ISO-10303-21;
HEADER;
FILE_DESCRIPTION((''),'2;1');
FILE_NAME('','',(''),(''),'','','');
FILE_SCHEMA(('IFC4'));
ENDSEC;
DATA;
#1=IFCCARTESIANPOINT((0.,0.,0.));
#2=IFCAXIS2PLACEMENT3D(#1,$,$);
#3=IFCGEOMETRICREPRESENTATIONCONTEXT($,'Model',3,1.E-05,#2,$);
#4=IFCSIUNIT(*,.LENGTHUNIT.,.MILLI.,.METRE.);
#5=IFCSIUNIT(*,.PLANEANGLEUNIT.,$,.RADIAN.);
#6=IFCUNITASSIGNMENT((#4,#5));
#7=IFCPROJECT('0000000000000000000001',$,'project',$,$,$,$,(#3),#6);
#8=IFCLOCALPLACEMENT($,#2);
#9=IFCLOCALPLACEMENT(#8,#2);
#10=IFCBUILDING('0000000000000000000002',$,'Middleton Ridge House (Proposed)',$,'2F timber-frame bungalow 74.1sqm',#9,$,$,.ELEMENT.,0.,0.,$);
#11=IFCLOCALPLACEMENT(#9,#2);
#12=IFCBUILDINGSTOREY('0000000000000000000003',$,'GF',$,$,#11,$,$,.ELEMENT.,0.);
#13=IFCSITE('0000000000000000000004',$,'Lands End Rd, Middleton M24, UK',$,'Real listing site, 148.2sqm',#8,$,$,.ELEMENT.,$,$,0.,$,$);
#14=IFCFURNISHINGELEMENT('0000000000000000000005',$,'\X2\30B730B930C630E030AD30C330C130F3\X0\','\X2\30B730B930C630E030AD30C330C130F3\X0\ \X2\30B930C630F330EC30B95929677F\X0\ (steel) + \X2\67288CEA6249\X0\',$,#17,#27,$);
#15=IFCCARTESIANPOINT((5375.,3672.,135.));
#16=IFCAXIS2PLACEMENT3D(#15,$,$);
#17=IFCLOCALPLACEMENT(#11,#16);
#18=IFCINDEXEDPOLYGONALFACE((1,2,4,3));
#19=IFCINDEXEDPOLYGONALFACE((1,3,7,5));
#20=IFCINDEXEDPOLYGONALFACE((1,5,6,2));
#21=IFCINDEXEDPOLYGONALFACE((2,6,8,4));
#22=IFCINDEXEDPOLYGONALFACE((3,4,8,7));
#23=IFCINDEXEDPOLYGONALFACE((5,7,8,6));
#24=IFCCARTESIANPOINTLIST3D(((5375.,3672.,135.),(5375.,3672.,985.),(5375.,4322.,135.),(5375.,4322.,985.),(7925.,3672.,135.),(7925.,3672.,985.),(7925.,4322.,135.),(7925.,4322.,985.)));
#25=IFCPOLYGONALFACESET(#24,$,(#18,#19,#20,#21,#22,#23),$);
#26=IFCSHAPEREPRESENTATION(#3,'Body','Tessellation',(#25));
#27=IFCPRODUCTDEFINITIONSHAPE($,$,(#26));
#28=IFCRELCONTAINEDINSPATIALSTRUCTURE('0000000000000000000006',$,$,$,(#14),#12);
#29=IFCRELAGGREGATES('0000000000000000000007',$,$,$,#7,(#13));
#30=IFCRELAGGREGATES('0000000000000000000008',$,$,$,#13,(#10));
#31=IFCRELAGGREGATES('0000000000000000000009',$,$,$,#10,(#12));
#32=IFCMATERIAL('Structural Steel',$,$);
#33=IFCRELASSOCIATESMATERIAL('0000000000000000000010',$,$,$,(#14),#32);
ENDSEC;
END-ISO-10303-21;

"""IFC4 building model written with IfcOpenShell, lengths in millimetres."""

from ifc_helpers import new_model, si_unit, frame, frame_2d, origin, place, context, project, spatial, rectangle, extrude, material, element, save


model = new_model("IFC4")

# Units and contexts
model_context = context("Model", 3, precision=1e-05, world=origin())
ifc_project = project(units=[si_unit("LENGTHUNIT", "METRE", prefix="MILLI"), si_unit("PLANEANGLEUNIT", "RADIAN")], contexts=[model_context])

# Site, building, storey
site_placement = place(None, origin())
site = spatial("IfcSite", under=ifc_project, at=site_placement, Name="Lands End Rd, Middleton M24, UK", ObjectType="Real listing site, 148.2sqm", CompositionType="ELEMENT", RefElevation=0.0)
building_placement = place(site_placement, origin())
building = spatial("IfcBuilding", under=site, at=building_placement, Name="Middleton Ridge House (Proposed)", ObjectType="2F timber-frame bungalow 74.1sqm", CompositionType="ELEMENT", ElevationOfRefHeight=0.0, ElevationOfTerrain=0.0)
storey_placement = place(building_placement, origin())
storey = spatial("IfcBuildingStorey", under=building, at=storey_placement, Name="GF", CompositionType="ELEMENT", Elevation=0.0)

# Furnishing element
ifc_material_1 = material(Name="Structural Steel")
furnishing_1_placement = place(storey_placement, frame((5375.0, 3672.0, 135.0)))
element("IfcFurnishingElement", 1, at=furnishing_1_placement, inside=storey, material=ifc_material_1, Name="システムキッチン", Description="システムキッチン ステンレス天板 (steel) + 木質扉", context=model_context, shape_type="SweptSolid", body=[
    extrude(rectangle(XDim=2550.0, YDim=650.0, at=frame_2d((1275.0, 325.0))), frame((5375.0, 3672.0, 135.0)), (0.0, 0.0, 1.0), 850.0),
])

save(model, "model.ifc")
